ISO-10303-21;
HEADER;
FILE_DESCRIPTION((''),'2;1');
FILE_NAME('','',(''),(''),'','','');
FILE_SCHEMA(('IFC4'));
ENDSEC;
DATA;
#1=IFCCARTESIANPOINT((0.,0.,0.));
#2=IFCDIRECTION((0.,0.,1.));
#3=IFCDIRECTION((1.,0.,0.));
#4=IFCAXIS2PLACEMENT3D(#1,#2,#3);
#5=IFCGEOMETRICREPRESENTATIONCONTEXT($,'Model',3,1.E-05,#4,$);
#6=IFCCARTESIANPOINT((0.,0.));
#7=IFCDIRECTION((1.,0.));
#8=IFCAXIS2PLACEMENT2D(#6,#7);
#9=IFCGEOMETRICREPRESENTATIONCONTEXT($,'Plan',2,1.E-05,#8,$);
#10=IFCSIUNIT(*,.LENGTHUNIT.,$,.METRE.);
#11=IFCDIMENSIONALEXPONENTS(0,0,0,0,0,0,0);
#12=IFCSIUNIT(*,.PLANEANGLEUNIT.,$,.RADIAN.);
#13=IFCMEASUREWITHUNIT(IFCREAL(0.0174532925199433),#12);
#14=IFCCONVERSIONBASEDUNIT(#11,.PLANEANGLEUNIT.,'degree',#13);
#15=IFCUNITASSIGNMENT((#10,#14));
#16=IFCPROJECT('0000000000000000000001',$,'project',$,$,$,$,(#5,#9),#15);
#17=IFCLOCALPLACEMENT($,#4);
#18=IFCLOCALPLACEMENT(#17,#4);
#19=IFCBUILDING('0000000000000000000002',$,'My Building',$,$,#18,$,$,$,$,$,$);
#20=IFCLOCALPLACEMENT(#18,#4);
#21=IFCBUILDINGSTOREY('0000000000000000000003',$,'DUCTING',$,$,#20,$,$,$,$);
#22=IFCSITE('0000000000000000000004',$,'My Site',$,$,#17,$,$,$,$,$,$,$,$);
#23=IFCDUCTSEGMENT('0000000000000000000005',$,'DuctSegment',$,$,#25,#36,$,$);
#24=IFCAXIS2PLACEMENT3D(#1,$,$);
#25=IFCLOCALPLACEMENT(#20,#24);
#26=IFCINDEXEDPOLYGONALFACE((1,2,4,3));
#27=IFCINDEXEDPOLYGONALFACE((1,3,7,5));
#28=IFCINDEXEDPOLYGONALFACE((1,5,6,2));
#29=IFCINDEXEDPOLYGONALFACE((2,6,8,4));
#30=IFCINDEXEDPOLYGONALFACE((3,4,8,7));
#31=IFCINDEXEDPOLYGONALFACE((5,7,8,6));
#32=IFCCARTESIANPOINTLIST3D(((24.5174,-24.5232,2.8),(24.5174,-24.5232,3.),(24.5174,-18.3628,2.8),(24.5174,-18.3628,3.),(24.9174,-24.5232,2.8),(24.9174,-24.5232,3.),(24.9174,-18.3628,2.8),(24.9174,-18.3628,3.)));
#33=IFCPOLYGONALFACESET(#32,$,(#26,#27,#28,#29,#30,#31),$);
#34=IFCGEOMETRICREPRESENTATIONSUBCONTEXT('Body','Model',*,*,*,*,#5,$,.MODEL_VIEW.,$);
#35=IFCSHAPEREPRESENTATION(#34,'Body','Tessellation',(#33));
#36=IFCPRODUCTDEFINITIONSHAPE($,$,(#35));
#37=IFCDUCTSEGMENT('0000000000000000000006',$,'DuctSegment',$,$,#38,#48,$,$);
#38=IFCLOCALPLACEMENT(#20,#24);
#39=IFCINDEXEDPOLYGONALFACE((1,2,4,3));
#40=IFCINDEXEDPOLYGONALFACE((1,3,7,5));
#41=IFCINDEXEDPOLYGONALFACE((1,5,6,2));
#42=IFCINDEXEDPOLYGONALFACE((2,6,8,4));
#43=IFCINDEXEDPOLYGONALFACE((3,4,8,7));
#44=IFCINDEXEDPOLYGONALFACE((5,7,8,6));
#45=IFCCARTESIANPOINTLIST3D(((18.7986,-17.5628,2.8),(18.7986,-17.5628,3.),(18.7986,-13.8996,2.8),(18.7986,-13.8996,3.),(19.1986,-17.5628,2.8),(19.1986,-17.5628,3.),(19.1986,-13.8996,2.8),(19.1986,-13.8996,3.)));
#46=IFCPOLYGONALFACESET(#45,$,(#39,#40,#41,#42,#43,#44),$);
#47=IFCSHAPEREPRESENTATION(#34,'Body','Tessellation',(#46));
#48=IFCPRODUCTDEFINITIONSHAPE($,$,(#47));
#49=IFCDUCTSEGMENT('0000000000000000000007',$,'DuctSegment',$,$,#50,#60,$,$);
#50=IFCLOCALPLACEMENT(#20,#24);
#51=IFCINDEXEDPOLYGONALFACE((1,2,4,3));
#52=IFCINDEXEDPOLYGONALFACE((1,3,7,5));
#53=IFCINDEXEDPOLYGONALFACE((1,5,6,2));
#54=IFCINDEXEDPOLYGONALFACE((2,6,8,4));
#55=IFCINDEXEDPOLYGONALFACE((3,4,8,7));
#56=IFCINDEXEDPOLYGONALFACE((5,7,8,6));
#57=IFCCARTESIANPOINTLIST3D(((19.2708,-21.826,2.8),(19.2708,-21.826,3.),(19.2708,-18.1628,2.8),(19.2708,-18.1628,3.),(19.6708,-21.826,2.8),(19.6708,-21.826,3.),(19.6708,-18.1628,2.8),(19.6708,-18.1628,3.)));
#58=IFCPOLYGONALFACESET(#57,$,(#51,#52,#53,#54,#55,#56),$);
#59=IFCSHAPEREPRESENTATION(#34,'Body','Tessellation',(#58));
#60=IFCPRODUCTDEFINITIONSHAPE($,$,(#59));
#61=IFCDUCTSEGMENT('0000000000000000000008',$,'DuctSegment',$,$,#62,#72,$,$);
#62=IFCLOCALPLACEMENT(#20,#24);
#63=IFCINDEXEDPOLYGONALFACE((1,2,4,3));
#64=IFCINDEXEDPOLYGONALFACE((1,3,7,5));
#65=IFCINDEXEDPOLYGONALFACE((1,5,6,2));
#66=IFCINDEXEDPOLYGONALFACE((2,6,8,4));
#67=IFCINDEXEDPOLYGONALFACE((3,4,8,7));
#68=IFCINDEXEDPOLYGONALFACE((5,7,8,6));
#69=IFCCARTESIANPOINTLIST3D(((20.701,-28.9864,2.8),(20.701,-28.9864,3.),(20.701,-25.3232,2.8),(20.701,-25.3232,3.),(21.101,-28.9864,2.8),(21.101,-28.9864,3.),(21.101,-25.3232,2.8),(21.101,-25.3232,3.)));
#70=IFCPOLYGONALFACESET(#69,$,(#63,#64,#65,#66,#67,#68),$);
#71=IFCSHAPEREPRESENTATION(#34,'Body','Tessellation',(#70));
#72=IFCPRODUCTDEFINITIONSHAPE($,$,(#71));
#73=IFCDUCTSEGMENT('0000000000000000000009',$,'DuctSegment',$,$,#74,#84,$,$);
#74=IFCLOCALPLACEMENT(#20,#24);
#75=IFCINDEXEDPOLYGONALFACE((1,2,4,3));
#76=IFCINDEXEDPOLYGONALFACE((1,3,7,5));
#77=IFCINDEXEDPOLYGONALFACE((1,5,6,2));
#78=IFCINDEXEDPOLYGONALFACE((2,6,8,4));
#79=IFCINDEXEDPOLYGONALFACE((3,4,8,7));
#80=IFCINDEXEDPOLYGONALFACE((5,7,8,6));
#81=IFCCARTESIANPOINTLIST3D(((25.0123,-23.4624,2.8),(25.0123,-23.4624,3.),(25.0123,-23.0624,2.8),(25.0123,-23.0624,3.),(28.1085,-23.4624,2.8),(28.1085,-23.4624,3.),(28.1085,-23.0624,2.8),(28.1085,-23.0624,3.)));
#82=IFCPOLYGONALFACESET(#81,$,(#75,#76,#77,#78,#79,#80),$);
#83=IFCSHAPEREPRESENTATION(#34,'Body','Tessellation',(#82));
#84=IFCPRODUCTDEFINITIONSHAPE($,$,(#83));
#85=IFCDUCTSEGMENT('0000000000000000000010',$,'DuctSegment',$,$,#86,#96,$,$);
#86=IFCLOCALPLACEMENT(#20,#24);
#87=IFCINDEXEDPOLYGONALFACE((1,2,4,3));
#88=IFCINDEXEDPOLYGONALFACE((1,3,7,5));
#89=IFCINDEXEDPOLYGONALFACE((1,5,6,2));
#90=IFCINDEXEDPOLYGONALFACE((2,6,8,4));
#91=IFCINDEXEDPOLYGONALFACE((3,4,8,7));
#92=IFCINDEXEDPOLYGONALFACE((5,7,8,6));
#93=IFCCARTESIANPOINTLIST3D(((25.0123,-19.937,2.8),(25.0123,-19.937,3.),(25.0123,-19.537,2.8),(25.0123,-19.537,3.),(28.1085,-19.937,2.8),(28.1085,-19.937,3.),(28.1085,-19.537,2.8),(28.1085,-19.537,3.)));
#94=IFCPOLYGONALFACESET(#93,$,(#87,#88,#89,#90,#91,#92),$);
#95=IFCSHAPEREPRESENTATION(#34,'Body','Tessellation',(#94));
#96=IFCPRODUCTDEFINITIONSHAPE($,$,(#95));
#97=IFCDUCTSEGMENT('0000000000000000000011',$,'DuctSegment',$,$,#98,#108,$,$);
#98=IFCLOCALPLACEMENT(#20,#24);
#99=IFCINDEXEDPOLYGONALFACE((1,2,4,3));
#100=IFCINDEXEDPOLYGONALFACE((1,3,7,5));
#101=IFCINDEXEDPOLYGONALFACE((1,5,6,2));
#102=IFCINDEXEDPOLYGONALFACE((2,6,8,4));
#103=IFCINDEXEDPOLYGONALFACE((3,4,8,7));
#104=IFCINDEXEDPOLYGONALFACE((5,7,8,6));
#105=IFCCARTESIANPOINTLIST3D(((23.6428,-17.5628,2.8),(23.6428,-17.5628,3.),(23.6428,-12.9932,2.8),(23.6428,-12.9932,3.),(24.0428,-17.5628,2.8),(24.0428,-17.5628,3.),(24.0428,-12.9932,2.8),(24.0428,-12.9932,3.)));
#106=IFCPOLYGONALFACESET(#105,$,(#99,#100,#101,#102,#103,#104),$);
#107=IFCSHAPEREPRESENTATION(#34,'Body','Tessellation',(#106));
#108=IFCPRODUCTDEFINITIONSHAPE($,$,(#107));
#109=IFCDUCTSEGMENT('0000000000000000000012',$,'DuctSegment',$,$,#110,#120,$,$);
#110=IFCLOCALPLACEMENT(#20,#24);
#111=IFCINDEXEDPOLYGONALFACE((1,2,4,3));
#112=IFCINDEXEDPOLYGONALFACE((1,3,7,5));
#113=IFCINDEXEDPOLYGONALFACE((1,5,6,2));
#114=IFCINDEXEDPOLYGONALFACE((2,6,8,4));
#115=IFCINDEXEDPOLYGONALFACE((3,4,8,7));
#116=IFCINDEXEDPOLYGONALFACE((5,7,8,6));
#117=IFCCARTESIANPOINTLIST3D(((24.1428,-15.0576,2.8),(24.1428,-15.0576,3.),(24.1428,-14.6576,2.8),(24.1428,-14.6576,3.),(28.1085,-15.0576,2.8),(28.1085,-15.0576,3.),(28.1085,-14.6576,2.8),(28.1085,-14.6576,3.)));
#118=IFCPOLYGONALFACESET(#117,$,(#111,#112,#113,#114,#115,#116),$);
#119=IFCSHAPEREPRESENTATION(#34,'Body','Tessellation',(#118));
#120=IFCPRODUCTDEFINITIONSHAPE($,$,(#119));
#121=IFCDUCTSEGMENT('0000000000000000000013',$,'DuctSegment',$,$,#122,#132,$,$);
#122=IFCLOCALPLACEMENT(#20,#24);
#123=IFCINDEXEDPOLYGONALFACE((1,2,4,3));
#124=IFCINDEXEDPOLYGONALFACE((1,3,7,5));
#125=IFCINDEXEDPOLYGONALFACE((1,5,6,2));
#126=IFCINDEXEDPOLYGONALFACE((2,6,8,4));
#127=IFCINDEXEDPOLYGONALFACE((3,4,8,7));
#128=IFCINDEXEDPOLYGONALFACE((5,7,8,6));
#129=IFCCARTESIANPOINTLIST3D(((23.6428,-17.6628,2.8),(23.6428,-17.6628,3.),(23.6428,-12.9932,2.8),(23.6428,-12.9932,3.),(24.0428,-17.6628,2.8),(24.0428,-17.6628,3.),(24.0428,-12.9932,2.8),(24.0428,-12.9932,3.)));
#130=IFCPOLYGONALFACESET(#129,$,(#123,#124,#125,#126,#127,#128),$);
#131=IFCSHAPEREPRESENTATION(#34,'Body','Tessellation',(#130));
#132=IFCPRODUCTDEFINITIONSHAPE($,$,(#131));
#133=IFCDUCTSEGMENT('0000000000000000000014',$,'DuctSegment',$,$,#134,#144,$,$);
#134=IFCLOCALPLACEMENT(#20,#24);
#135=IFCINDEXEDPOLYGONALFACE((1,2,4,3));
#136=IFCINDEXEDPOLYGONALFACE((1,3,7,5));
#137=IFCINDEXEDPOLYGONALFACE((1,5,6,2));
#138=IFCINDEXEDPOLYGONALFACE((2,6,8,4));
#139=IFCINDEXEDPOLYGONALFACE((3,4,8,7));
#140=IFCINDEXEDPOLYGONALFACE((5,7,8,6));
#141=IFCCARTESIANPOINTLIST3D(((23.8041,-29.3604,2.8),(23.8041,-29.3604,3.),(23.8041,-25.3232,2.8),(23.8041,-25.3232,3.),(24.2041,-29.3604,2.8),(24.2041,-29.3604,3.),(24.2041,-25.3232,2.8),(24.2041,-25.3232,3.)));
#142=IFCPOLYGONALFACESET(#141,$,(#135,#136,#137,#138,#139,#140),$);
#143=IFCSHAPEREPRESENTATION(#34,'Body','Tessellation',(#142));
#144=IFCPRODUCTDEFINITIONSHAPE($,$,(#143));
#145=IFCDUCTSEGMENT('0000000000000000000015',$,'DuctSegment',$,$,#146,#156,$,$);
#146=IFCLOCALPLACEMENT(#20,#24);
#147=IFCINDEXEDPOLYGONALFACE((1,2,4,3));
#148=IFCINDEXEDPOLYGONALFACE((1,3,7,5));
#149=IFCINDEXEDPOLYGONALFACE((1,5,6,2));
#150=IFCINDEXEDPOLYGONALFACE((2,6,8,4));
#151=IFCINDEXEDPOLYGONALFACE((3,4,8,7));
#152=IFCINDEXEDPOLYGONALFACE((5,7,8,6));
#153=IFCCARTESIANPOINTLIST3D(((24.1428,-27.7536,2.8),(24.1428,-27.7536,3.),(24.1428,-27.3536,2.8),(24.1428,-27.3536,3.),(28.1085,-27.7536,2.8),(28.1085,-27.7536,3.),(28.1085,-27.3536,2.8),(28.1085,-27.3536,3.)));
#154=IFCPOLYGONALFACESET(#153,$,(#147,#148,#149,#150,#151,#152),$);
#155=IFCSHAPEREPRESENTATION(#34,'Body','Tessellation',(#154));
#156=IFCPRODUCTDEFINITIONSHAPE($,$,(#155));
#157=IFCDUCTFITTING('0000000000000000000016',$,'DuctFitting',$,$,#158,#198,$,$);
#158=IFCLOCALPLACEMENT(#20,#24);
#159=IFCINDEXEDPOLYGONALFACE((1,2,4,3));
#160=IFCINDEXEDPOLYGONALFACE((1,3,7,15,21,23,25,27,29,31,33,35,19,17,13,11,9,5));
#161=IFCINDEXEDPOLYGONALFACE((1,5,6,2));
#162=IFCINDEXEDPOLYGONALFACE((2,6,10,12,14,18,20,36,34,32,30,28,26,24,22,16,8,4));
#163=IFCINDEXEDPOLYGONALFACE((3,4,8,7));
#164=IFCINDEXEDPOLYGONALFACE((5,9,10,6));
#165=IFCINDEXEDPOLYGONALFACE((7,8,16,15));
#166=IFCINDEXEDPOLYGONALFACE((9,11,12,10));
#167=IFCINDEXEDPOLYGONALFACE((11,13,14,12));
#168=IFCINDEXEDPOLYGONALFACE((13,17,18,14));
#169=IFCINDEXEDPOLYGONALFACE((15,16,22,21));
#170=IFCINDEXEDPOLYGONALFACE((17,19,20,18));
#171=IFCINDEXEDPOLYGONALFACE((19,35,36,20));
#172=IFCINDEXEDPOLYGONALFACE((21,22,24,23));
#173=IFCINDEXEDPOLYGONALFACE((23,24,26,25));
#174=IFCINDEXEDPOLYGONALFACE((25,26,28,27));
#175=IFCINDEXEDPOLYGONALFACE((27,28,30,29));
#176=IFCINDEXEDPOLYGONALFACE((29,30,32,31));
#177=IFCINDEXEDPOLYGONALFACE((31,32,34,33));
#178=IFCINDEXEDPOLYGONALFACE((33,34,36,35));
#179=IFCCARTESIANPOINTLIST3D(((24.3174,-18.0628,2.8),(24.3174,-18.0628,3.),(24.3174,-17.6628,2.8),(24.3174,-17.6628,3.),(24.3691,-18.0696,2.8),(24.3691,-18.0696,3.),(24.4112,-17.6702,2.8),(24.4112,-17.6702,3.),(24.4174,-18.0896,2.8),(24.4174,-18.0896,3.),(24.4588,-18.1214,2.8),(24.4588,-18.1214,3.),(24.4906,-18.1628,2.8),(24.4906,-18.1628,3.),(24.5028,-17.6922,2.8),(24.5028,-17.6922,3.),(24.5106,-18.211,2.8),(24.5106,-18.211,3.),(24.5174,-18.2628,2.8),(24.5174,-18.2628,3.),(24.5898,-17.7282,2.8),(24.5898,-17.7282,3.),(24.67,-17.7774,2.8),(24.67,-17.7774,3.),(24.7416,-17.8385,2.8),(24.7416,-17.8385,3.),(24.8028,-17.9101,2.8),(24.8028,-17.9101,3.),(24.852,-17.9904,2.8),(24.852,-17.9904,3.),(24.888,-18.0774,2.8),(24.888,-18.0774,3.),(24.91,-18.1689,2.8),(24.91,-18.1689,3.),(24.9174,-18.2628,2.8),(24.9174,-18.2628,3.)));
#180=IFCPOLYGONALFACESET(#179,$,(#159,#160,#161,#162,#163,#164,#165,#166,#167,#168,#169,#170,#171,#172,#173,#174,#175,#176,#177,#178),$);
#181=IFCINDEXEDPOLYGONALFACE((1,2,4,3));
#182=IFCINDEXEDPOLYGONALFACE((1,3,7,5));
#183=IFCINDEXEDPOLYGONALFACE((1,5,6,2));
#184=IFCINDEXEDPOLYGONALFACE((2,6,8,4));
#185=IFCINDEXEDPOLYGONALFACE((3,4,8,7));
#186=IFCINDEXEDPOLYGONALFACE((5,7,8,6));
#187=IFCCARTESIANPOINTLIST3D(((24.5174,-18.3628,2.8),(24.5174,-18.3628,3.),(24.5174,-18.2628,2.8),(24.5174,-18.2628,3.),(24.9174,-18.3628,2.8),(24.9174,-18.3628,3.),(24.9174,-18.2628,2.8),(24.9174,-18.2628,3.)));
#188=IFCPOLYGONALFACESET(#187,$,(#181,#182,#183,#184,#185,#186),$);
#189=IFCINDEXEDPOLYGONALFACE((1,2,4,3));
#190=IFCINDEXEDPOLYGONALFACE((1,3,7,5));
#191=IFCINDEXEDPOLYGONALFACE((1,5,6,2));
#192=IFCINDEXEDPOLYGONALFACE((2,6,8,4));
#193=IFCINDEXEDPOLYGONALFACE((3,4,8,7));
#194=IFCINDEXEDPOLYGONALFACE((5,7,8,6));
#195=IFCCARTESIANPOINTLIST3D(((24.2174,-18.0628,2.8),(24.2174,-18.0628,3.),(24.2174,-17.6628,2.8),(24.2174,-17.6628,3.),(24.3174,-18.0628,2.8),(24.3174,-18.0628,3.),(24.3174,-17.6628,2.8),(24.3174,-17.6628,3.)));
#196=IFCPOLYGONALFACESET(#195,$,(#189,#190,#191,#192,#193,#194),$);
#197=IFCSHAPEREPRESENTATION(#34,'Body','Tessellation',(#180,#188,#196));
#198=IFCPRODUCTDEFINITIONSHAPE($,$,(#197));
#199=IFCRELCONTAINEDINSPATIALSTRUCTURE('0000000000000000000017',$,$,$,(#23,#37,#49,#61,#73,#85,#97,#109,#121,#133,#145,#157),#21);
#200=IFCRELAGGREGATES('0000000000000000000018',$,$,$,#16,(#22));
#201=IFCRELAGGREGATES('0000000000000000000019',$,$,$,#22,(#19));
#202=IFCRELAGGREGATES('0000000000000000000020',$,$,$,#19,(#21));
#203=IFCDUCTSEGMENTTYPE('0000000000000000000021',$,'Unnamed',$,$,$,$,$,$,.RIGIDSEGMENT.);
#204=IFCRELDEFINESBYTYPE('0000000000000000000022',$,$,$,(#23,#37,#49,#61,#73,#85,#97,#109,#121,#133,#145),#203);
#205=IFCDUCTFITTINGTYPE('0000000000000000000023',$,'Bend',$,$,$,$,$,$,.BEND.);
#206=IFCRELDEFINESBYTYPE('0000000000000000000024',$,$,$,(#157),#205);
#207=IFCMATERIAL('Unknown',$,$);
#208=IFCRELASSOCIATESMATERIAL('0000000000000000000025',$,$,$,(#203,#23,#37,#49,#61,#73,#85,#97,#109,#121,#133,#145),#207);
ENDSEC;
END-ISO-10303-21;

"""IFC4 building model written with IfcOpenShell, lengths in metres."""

from ifc_helpers import new_model, entity, si_unit, converted_unit, frame, origin_with_axes, origin_2d_with_axis, place, context, subcontext, project, spatial, line, arc, indexed_curve, rectangle, outline, extrude, source, transform, mapped, material, material_profile, profile_set, profile_usage, type_object, type_shapes, element, save


model = new_model("IFC4")

# Units and contexts
model_context = context("Model", 3, precision=1e-05, world=origin_with_axes())
plan_context = context("Plan", 2, precision=1e-05, world=origin_2d_with_axis())
body_context = subcontext(model_context, "Body", "Model", "MODEL_VIEW")
ifc_project = project(units=[si_unit("LENGTHUNIT", "METRE"), converted_unit("PLANEANGLEUNIT", "degree", entity("IfcReal", 0.0174532925199433), si_unit("PLANEANGLEUNIT", "RADIAN"), dimensions=[0, 0, 0, 0, 0, 0, 0])], contexts=[model_context, plan_context])

# Site, building, storey
site_placement = place(None, origin_with_axes())
site = spatial("IfcSite", under=ifc_project, at=site_placement, Name="My Site")
building_placement = place(site_placement, origin_with_axes())
building = spatial("IfcBuilding", under=site, at=building_placement, Name="My Building")
storey_placement = place(building_placement, origin_with_axes())
storey = spatial("IfcBuildingStorey", under=building, at=storey_placement, Name="DUCTING")

# Duct segments
ifc_material = material(Name="Unknown")
ifc_material_profile_1 = material_profile(ifc_material, rectangle(XDim=0.4, YDim=0.2))
ifc_profile_set_1 = profile_set([ifc_material_profile_1])
ifc_profile_usage_1 = profile_usage(ifc_profile_set_1, cardinal=5)
duct_segment_type = type_object("IfcDuctSegmentType", Name="Unnamed", PredefinedType="RIGIDSEGMENT", material=ifc_profile_set_1)
duct_segment_1_placement = place(storey_placement, frame((24.7174, -18.3628, 2.9), z_axis=(0.0, -1.0, 0.0), x_axis=(1.0, 0.0, 0.0)))
element("IfcDuctSegment", 1, at=duct_segment_1_placement, inside=storey, type_object=duct_segment_type, material=ifc_profile_usage_1, Name="DuctSegment", context=body_context, shape_type="SweptSolid", body=[
    extrude(rectangle(XDim=0.4, YDim=0.2), origin_with_axes(), (0.0, 0.0, 1.0), 6.1604),
])
ifc_profile_usage_2 = profile_usage(ifc_profile_set_1, cardinal=5)
duct_segment_2_placement = place(storey_placement, frame((18.9986, -17.5628, 2.9), z_axis=(0.0, 1.0, 0.0), x_axis=(-1.0, 0.0, 0.0)))
element("IfcDuctSegment", 2, at=duct_segment_2_placement, inside=storey, type_object=duct_segment_type, material=ifc_profile_usage_2, Name="DuctSegment", context=body_context, shape_type="SweptSolid", body=[
    extrude(rectangle(XDim=0.4, YDim=0.2), origin_with_axes(), (0.0, 0.0, 1.0), 3.6632),
])
ifc_profile_usage_3 = profile_usage(ifc_profile_set_1, cardinal=5)
duct_segment_3_placement = place(storey_placement, frame((19.4708, -18.1628, 2.9), z_axis=(0.0, -1.0, 0.0), x_axis=(1.0, 0.0, 0.0)))
element("IfcDuctSegment", 3, at=duct_segment_3_placement, inside=storey, type_object=duct_segment_type, material=ifc_profile_usage_3, Name="DuctSegment", context=body_context, shape_type="SweptSolid", body=[
    extrude(rectangle(XDim=0.4, YDim=0.2), origin_with_axes(), (0.0, 0.0, 1.0), 3.6632),
])
ifc_profile_usage_4 = profile_usage(ifc_profile_set_1, cardinal=5)
duct_segment_4_placement = place(storey_placement, frame((20.901, -25.3232, 2.9), z_axis=(0.0, -1.0, 0.0), x_axis=(1.0, 0.0, 0.0)))
element("IfcDuctSegment", 4, at=duct_segment_4_placement, inside=storey, type_object=duct_segment_type, material=ifc_profile_usage_4, Name="DuctSegment", context=body_context, shape_type="SweptSolid", body=[
    extrude(rectangle(XDim=0.4, YDim=0.2), origin_with_axes(), (0.0, 0.0, 1.0), 3.6632),
])
ifc_profile_usage_5 = profile_usage(ifc_profile_set_1, cardinal=5)
duct_segment_5_placement = place(storey_placement, frame((25.0123, -23.2624, 2.9), z_axis=(1.0, 0.0, 0.0), x_axis=(0.0, 1.0, 0.0)))
element("IfcDuctSegment", 5, at=duct_segment_5_placement, inside=storey, type_object=duct_segment_type, material=ifc_profile_usage_5, Name="DuctSegment", context=body_context, shape_type="SweptSolid", body=[
    extrude(rectangle(XDim=0.4, YDim=0.2), origin_with_axes(), (0.0, 0.0, 1.0), 3.0962),
])
ifc_profile_usage_6 = profile_usage(ifc_profile_set_1, cardinal=5)
duct_segment_6_placement = place(storey_placement, frame((25.0123, -19.737, 2.9), z_axis=(1.0, 0.0, 0.0), x_axis=(0.0, 1.0, 0.0)))
element("IfcDuctSegment", 6, at=duct_segment_6_placement, inside=storey, type_object=duct_segment_type, material=ifc_profile_usage_6, Name="DuctSegment", context=body_context, shape_type="SweptSolid", body=[
    extrude(rectangle(XDim=0.4, YDim=0.2), origin_with_axes(), (0.0, 0.0, 1.0), 3.0962),
])
ifc_profile_usage_7 = profile_usage(ifc_profile_set_1, cardinal=5)
duct_segment_7_placement = place(storey_placement, frame((23.8428, -17.5628, 2.9), z_axis=(0.0, 1.0, 0.0), x_axis=(-1.0, 0.0, 0.0)))
element("IfcDuctSegment", 7, at=duct_segment_7_placement, inside=storey, type_object=duct_segment_type, material=ifc_profile_usage_7, Name="DuctSegment", context=body_context, shape_type="SweptSolid", body=[
    extrude(rectangle(XDim=0.4, YDim=0.2), origin_with_axes(), (0.0, 0.0, 1.0), 4.5696),
])
ifc_profile_usage_8 = profile_usage(ifc_profile_set_1, cardinal=5)
duct_segment_8_placement = place(storey_placement, frame((24.1428, -14.8576, 2.9), z_axis=(1.0, 0.0, 0.0), x_axis=(0.0, 1.0, 0.0)))
element("IfcDuctSegment", 8, at=duct_segment_8_placement, inside=storey, type_object=duct_segment_type, material=ifc_profile_usage_8, Name="DuctSegment", context=body_context, shape_type="SweptSolid", body=[
    extrude(rectangle(XDim=0.4, YDim=0.2), origin_with_axes(), (0.0, 0.0, 1.0), 3.9656),
])
ifc_profile_usage_9 = profile_usage(ifc_profile_set_1, cardinal=5)
duct_segment_9_placement = place(storey_placement, frame((23.8428, -17.6628, 2.9), z_axis=(0.0, 1.0, 0.0), x_axis=(-1.0, 0.0, 0.0)))
element("IfcDuctSegment", 9, at=duct_segment_9_placement, inside=storey, type_object=duct_segment_type, material=ifc_profile_usage_9, Name="DuctSegment", context=body_context, shape_type="SweptSolid", body=[
    extrude(rectangle(XDim=0.4, YDim=0.2), origin_with_axes(), (0.0, 0.0, 1.0), 4.6696),
])
ifc_profile_usage_10 = profile_usage(ifc_profile_set_1, cardinal=5)
duct_segment_10_placement = place(storey_placement, frame((24.0041, -25.3232, 2.9), z_axis=(0.0, -1.0, 0.0), x_axis=(1.0, 0.0, 0.0)))
element("IfcDuctSegment", 10, at=duct_segment_10_placement, inside=storey, type_object=duct_segment_type, material=ifc_profile_usage_10, Name="DuctSegment", context=body_context, shape_type="SweptSolid", body=[
    extrude(rectangle(XDim=0.4, YDim=0.2), origin_with_axes(), (0.0, 0.0, 1.0), 4.0371),
])
ifc_profile_usage_11 = profile_usage(ifc_profile_set_1, cardinal=5)
duct_segment_11_placement = place(storey_placement, frame((24.1428, -27.5536, 2.9), z_axis=(1.0, 0.0, 0.0), x_axis=(0.0, 1.0, 0.0)))
element("IfcDuctSegment", 11, at=duct_segment_11_placement, inside=storey, type_object=duct_segment_type, material=ifc_profile_usage_11, Name="DuctSegment", context=body_context, shape_type="SweptSolid", body=[
    extrude(rectangle(XDim=0.4, YDim=0.2), origin_with_axes(), (0.0, 0.0, 1.0), 3.9656),
])

# Duct fitting
duct_fitting_type_1 = type_object("IfcDuctFittingType", Name="Bend", PredefinedType="BEND")
shared_shape = source(origin_with_axes(), body_context, "Body", "SweptSolid", [
    extrude(outline(indexed_curve([(-0.2, 0.0), (-0.2586, -0.1414), (-0.4, -0.2), (-0.4, -0.6), (0.0243, -0.4243), (0.2, 0.0)], segments=[arc(1, 2, 3), line(3, 4), arc(4, 5, 6), line(6, 1)])), frame((0.0, -0.1, -0.1), z_axis=(0.0, -1.0, 0.0), x_axis=(1.0, 0.0, 0.0)), (0.0, 0.0, -1.0), 0.2),
    extrude(rectangle(XDim=0.4, YDim=0.2), origin_with_axes(), (0.0, 0.0, -1.0), 0.1),
    extrude(rectangle(XDim=0.4, YDim=0.2), frame((-0.4, 0.0, -0.5), z_axis=(-1.0, 0.0, 0.0), x_axis=(0.0, 0.0, -1.0)), (0.0, 0.0, 1.0), 0.1),
])
type_shapes(duct_fitting_type_1, [shared_shape])
for number, where, z_axis, x_axis, name in (
    (12, (24.7174, -18.3628, 2.9), (0.0, -1.0, 0.0), (1.0, 0.0, 0.0), "DuctFitting"),
):
    element("IfcDuctFitting", number, at=place(storey_placement, frame(where, z_axis=z_axis, x_axis=x_axis)), inside=storey, type_object=duct_fitting_type_1, Name=name, context=body_context, shape_type="MappedRepresentation", body=[
        mapped(shared_shape, transform((0.0, 0.0, 0.0), x_axis=(1.0, 0.0, 0.0), y_axis=(0.0, 1.0, 0.0), z_axis=(0.0, 0.0, 1.0), scale=1.0)),
    ])

save(model, "model.ifc")
